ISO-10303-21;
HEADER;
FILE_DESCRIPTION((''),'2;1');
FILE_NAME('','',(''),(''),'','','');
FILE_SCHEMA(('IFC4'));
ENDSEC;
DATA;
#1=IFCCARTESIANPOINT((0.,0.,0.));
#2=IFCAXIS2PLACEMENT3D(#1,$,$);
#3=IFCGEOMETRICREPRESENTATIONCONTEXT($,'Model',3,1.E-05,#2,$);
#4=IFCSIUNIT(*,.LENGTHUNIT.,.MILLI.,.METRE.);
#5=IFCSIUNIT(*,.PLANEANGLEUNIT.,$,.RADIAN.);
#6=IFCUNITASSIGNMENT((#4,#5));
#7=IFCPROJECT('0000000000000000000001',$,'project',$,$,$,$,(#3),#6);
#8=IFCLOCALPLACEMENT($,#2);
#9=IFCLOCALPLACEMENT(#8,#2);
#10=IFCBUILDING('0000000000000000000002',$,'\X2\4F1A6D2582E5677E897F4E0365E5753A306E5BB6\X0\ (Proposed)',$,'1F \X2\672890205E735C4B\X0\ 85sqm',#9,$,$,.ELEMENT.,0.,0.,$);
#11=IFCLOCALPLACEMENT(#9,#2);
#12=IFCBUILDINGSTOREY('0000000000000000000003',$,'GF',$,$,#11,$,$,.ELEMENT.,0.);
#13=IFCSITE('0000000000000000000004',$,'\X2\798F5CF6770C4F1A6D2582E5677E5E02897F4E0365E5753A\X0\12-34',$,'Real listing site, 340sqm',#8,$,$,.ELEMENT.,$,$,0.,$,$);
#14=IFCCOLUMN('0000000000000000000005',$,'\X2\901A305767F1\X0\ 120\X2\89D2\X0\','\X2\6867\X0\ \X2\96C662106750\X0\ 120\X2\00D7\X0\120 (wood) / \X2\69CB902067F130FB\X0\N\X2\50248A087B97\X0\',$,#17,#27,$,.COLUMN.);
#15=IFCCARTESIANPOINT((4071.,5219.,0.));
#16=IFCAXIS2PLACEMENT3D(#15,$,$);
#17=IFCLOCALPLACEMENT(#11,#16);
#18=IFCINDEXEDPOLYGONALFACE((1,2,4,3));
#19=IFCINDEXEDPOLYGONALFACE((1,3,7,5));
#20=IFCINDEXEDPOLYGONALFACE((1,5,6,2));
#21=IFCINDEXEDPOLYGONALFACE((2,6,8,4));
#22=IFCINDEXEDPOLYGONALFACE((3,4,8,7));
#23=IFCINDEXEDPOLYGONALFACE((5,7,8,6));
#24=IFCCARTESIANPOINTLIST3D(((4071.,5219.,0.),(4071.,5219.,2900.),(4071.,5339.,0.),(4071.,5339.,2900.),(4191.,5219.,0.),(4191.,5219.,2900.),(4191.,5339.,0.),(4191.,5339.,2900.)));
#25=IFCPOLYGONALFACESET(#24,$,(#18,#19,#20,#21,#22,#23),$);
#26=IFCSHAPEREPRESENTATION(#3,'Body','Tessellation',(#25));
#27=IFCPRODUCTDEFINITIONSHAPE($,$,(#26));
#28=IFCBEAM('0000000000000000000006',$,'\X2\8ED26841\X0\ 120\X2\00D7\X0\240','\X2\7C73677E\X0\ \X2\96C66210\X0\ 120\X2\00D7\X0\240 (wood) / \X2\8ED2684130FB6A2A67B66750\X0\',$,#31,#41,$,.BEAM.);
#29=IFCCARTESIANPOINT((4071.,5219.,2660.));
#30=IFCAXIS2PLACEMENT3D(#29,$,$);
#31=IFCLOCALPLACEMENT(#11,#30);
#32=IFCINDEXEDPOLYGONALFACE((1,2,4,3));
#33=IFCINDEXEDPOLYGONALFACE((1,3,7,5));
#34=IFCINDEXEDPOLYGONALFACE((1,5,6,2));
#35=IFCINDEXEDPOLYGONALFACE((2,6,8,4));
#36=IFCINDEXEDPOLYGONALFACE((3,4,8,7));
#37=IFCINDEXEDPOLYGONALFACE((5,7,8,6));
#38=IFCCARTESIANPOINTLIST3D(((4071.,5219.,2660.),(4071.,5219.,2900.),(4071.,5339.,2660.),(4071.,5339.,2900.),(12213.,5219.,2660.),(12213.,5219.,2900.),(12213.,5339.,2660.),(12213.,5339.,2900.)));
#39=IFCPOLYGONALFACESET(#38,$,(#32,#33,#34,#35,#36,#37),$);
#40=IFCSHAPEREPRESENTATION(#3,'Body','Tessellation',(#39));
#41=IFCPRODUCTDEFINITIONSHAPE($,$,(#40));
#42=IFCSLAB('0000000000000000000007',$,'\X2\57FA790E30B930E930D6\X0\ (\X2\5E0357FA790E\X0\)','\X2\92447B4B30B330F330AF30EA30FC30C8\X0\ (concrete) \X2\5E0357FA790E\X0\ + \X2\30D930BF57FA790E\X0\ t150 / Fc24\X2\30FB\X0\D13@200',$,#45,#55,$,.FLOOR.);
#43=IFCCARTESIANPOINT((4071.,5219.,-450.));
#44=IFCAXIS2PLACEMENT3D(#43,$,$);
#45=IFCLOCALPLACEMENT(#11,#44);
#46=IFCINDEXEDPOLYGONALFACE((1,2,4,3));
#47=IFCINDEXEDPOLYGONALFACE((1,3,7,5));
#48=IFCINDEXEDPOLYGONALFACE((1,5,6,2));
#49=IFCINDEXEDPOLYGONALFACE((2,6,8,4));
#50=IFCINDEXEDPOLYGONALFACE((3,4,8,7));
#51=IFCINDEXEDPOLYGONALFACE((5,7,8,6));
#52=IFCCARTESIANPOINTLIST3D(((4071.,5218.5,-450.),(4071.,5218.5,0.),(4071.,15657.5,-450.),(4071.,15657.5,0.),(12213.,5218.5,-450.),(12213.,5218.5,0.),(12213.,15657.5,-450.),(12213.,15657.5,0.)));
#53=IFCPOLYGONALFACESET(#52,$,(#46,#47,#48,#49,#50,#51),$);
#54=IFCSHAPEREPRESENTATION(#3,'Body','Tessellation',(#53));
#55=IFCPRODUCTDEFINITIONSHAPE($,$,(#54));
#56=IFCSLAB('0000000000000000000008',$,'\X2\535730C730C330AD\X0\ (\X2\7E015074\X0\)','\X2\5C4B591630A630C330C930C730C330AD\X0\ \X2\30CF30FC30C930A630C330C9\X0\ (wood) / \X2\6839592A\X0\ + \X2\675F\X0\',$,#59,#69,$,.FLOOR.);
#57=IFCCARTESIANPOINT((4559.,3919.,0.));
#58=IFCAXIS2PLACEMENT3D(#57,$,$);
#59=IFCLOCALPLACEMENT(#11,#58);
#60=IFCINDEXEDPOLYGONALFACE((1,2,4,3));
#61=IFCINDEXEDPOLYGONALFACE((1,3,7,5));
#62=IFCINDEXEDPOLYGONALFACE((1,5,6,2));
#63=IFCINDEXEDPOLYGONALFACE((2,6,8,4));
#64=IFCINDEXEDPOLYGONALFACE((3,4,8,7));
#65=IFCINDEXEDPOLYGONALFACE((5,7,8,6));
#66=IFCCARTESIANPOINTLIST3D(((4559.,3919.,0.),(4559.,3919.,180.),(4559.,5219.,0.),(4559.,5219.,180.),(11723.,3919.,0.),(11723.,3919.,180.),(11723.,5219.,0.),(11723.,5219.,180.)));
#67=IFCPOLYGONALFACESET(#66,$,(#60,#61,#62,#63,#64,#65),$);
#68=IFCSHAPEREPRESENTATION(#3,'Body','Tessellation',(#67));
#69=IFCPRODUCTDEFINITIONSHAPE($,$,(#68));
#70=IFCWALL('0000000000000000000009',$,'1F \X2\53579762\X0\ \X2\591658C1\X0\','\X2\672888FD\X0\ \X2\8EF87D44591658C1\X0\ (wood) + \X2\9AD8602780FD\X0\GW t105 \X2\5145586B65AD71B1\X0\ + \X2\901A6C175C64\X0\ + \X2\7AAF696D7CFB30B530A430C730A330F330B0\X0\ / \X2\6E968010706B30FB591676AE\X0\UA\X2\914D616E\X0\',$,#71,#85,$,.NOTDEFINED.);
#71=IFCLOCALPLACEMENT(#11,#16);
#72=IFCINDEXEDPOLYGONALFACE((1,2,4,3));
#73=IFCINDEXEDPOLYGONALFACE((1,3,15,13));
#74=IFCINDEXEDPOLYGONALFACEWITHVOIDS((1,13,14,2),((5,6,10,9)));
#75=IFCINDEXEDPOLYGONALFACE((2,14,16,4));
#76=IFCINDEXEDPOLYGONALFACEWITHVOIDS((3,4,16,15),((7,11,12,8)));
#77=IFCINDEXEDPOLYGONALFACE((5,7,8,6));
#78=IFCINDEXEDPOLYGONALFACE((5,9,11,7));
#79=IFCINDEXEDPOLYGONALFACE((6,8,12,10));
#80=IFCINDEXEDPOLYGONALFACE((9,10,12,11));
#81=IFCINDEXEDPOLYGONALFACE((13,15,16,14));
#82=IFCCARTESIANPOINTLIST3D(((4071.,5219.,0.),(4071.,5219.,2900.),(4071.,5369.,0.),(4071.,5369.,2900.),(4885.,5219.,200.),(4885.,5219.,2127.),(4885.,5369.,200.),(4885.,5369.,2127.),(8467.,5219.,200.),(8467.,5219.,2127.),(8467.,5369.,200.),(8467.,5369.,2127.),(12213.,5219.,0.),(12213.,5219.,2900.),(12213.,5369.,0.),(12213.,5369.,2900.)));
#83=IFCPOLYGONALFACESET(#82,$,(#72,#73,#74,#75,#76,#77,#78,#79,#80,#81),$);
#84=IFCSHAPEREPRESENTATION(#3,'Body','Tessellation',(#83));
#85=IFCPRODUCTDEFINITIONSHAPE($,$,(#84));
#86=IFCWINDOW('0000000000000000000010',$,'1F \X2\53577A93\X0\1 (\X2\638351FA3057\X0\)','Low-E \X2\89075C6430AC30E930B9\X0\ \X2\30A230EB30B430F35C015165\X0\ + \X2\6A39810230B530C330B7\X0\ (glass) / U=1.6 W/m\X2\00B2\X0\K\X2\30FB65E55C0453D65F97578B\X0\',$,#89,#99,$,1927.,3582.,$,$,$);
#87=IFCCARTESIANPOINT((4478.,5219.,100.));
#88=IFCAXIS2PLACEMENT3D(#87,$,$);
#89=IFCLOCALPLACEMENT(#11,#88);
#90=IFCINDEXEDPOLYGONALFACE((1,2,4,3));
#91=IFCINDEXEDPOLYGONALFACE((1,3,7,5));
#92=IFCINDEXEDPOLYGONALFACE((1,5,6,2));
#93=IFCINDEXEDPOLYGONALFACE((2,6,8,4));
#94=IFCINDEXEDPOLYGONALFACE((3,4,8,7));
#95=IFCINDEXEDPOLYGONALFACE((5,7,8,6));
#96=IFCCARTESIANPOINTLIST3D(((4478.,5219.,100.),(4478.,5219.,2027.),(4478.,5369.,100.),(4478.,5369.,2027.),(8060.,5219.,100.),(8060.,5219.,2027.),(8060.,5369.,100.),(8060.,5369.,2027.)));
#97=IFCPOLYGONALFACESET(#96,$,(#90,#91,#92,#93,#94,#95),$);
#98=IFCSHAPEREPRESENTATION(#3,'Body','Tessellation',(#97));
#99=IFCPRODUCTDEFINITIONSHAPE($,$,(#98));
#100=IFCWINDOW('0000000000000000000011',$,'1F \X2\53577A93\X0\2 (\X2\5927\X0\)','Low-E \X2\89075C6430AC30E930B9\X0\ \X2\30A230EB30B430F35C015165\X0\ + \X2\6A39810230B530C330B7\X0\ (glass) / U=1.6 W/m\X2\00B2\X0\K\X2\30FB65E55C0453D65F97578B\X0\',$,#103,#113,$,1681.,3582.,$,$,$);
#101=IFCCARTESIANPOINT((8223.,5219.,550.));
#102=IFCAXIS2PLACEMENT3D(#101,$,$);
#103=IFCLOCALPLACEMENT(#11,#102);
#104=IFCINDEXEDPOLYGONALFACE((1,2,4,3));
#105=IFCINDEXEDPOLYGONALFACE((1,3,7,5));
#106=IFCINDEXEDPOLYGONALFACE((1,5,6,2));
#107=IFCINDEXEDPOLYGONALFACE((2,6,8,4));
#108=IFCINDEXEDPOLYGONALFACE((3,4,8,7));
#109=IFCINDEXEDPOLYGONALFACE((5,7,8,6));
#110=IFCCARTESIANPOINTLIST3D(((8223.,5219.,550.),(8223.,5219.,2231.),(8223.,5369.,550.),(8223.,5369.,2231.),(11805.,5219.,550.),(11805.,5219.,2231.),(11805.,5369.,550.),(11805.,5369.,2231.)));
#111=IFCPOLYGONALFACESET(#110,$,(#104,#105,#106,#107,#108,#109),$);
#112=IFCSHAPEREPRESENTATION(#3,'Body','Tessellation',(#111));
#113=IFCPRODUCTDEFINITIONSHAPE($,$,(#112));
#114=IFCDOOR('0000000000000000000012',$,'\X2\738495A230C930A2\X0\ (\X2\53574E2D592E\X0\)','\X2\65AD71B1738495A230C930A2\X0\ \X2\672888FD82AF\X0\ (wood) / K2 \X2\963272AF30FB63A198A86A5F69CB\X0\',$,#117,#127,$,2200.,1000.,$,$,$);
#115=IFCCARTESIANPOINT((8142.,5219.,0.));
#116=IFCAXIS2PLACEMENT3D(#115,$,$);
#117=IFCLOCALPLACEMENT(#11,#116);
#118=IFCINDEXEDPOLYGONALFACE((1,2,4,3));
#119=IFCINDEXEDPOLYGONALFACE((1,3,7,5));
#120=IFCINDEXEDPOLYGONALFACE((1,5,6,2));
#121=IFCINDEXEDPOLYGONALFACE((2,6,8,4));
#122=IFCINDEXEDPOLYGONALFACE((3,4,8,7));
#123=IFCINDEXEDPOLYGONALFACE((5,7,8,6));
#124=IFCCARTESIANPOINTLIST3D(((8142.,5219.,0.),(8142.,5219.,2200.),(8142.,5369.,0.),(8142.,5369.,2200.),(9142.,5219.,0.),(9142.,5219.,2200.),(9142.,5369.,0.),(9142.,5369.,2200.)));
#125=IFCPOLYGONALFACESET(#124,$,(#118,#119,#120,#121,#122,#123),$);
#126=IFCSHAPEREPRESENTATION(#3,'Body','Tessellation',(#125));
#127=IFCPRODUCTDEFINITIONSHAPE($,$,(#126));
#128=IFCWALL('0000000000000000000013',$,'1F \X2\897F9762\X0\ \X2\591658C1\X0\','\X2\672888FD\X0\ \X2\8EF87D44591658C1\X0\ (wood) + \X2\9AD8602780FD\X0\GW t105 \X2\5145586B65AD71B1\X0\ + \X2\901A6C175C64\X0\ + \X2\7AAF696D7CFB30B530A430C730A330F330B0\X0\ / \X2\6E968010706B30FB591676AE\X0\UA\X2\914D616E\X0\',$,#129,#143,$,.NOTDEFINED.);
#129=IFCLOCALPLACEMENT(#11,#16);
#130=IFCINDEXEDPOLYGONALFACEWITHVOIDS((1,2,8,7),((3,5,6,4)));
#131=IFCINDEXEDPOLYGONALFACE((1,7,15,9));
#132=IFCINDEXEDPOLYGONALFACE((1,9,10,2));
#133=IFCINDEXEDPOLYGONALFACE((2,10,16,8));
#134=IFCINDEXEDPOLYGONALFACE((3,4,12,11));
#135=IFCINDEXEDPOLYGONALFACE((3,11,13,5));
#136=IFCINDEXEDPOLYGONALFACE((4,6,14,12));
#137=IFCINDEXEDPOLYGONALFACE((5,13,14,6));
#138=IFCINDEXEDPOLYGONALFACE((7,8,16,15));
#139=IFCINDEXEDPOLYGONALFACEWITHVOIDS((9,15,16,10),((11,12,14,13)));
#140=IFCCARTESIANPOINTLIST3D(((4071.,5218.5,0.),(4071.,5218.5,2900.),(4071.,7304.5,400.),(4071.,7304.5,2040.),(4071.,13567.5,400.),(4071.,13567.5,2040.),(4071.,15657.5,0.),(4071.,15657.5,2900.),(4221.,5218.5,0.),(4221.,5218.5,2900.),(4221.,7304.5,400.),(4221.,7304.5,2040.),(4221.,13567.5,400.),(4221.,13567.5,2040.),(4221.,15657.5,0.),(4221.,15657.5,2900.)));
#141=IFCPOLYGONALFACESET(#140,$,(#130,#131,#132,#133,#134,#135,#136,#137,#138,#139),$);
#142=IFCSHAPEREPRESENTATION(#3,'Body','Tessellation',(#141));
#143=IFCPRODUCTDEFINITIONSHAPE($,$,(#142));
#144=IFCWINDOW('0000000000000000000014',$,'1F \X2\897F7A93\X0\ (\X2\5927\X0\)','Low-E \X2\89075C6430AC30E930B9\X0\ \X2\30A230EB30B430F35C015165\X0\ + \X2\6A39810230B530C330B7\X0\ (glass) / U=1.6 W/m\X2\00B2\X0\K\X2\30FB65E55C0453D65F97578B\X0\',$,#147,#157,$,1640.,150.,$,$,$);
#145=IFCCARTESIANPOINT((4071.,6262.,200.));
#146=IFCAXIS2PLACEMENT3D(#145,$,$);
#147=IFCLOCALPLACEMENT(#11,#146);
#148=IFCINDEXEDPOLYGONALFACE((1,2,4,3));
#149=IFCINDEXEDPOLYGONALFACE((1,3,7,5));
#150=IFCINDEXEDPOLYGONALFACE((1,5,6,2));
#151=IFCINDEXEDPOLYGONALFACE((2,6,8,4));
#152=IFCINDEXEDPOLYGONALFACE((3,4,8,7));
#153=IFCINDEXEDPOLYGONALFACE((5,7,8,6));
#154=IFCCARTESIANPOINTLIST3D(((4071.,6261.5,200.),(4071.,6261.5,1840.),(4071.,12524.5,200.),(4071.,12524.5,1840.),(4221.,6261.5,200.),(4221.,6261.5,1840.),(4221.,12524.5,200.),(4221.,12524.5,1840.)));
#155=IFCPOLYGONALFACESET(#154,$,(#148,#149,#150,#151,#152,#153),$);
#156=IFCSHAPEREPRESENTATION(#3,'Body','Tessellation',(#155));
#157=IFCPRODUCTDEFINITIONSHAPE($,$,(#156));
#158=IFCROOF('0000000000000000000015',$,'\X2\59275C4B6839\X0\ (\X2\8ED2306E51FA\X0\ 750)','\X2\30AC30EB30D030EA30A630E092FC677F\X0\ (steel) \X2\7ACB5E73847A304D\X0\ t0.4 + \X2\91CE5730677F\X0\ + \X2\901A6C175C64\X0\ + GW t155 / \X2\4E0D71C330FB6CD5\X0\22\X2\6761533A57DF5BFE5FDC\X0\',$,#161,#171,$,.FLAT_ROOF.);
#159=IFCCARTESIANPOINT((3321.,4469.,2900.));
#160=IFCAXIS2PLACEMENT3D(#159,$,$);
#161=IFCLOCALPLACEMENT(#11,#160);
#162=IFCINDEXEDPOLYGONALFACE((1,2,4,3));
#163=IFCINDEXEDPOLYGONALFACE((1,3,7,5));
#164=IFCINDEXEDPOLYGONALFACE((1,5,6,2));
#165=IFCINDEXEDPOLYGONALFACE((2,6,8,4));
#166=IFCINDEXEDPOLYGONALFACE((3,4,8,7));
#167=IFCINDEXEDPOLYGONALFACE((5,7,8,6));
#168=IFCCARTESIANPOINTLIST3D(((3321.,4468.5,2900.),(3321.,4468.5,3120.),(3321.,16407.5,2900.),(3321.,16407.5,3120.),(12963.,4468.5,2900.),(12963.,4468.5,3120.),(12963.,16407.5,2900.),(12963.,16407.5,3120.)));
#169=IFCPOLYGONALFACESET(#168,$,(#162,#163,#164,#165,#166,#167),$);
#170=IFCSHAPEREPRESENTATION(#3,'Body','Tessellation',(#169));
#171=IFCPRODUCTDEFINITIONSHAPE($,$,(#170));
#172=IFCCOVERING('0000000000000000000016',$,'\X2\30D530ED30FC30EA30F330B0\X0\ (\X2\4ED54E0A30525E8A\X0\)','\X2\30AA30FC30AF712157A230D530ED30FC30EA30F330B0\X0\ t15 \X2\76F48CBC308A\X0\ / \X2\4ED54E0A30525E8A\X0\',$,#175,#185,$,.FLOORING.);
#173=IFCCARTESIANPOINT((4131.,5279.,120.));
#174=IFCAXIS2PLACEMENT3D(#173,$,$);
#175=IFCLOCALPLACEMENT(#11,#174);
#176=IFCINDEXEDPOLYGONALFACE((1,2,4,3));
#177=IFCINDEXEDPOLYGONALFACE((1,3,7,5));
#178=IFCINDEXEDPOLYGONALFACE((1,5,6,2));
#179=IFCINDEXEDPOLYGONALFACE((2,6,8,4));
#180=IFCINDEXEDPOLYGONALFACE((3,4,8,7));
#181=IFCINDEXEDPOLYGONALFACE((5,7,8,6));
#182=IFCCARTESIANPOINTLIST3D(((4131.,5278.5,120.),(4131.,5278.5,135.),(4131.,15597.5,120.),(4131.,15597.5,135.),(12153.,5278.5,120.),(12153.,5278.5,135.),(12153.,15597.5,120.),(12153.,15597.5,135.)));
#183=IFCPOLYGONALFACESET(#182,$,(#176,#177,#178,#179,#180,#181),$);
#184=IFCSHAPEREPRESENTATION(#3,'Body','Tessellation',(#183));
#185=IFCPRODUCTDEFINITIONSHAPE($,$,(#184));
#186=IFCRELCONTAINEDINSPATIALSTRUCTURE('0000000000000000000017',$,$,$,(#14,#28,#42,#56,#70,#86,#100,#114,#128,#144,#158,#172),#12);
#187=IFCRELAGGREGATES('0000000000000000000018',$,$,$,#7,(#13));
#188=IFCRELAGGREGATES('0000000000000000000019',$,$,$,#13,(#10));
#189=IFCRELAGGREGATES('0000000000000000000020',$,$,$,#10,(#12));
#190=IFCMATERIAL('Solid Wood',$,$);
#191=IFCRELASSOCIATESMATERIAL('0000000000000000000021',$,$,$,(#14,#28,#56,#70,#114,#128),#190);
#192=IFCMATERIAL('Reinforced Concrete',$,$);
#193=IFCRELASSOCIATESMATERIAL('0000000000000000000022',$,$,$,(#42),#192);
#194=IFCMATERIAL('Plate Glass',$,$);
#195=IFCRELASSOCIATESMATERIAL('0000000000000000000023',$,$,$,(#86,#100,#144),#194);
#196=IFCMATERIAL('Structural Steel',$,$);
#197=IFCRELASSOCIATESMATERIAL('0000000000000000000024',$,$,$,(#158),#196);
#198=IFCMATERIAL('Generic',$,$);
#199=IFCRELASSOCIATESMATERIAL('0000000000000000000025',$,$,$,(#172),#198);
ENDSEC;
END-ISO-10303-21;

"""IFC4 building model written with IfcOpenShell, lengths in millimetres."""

from ifc_helpers import new_model, si_unit, frame, frame_2d, origin, place, context, project, spatial, rectangle, extrude, material, element, fill, save


model = new_model("IFC4")

# Units and contexts
model_context = context("Model", 3, precision=1e-05, world=origin())
ifc_project = project(units=[si_unit("LENGTHUNIT", "METRE", prefix="MILLI"), si_unit("PLANEANGLEUNIT", "RADIAN")], contexts=[model_context])

# Site, building, storey
site_placement = place(None, origin())
site = spatial("IfcSite", under=ifc_project, at=site_placement, Name="福島県会津若松市西七日町12-34", ObjectType="Real listing site, 340sqm", CompositionType="ELEMENT", RefElevation=0.0)
building_placement = place(site_placement, origin())
building = spatial("IfcBuilding", under=site, at=building_placement, Name="会津若松西七日町の家 (Proposed)", ObjectType="1F 木造平屋 85sqm", CompositionType="ELEMENT", ElevationOfRefHeight=0.0, ElevationOfTerrain=0.0)
storey_placement = place(building_placement, origin())
storey = spatial("IfcBuildingStorey", under=building, at=storey_placement, Name="GF", CompositionType="ELEMENT", Elevation=0.0)

# Column
ifc_material_1 = material(Name="Solid Wood")
column_1_placement = place(storey_placement, frame((4071.0, 5219.0, 0.0)))
element("IfcColumn", 1, at=column_1_placement, inside=storey, material=ifc_material_1, Name="通し柱 120角", Description="桧 集成材 120×120 (wood) / 構造柱・N値計算", PredefinedType="COLUMN", context=model_context, shape_type="SweptSolid", body=[
    extrude(rectangle(XDim=120.0, YDim=120.0, at=frame_2d((60.0, 60.0))), frame((4071.0, 5219.0, 0.0)), (0.0, 0.0, 1.0), 2900.0),
])

# Beam
beam_1_placement = place(storey_placement, frame((4071.0, 5219.0, 2660.0)))
element("IfcBeam", 2, at=beam_1_placement, inside=storey, material=ifc_material_1, Name="軒桁 120×240", Description="米松 集成 120×240 (wood) / 軒桁・横架材", PredefinedType="BEAM", context=model_context, shape_type="SweptSolid", body=[
    extrude(rectangle(XDim=8142.0, YDim=120.0, at=frame_2d((4071.0, 60.0))), frame((4071.0, 5219.0, 2660.0)), (0.0, 0.0, 1.0), 240.0),
])

# Slabs
ifc_material_2 = material(Name="Reinforced Concrete")
slab_1_placement = place(storey_placement, frame((4071.0, 5219.0, -450.0)))
element("IfcSlab", 3, at=slab_1_placement, inside=storey, material=ifc_material_2, Name="基礎スラブ (布基礎)", Description="鉄筋コンクリート (concrete) 布基礎 + ベタ基礎 t150 / Fc24・D13@200", PredefinedType="FLOOR", context=model_context, shape_type="SweptSolid", body=[
    extrude(rectangle(XDim=8142.0, YDim=10439.0, at=frame_2d((4071.0, 5219.0))), frame((4071.0, 5219.0, -450.0)), (0.0, 0.0, 1.0), 450.0),
])
slab_2_placement = place(storey_placement, frame((4559.0, 3919.0, 0.0)))
element("IfcSlab", 4, at=slab_2_placement, inside=storey, material=ifc_material_1, Name="南デッキ (縁側)", Description="屋外ウッドデッキ ハードウッド (wood) / 根太 + 束", PredefinedType="FLOOR", context=model_context, shape_type="SweptSolid", body=[
    extrude(rectangle(XDim=7164.0, YDim=1300.0, at=frame_2d((3582.0, 650.0))), frame((4559.0, 3919.0, 0.0)), (0.0, 0.0, 1.0), 180.0),
])

# Wall, openings, windows, door
wall_1_placement = place(storey_placement, frame((4071.0, 5219.0, 0.0)))
wall_1 = element("IfcWall", 5, at=wall_1_placement, inside=storey, material=ifc_material_1, Name="1F 南面 外壁", Description="木製 軸組外壁 (wood) + 高性能GW t105 充填断熱 + 通気層 + 窯業系サイディング / 準耐火・外皮UA配慮", PredefinedType="NOTDEFINED", context=model_context, shape_type="SweptSolid", body=[
    extrude(rectangle(XDim=8142.0, YDim=150.0, at=frame_2d((4071.0, 75.0))), frame((4071.0, 5219.0, 0.0)), (0.0, 0.0, 1.0), 2900.0),
])
opening_1_placement = place(storey_placement, frame((4478.0, 5219.0, 100.0)))
opening_1 = element("IfcOpeningElement", 6, at=opening_1_placement, cuts=wall_1, PredefinedType="NOTDEFINED", context=model_context, shape_type="SweptSolid", body=[
    extrude(rectangle(XDim=3582.0, YDim=150.0, at=frame_2d((1791.0, 75.0))), frame((4478.0, 5219.0, 100.0)), (0.0, 0.0, 1.0), 1927.0),
])
opening_2_placement = place(storey_placement, frame((8223.0, 5219.0, 550.0)))
opening_2 = element("IfcOpeningElement", 7, at=opening_2_placement, cuts=wall_1, PredefinedType="NOTDEFINED", context=model_context, shape_type="SweptSolid", body=[
    extrude(rectangle(XDim=3582.0, YDim=150.0, at=frame_2d((1791.0, 75.0))), frame((8223.0, 5219.0, 550.0)), (0.0, 0.0, 1.0), 1681.0),
])
opening_3_placement = place(storey_placement, frame((8142.0, 5219.0, 0.0)))
opening_3 = element("IfcOpeningElement", 8, at=opening_3_placement, cuts=wall_1, PredefinedType="NOTDEFINED", context=model_context, shape_type="SweptSolid", body=[
    extrude(rectangle(XDim=1000.0, YDim=150.0, at=frame_2d((500.0, 75.0))), frame((8142.0, 5219.0, 0.0)), (0.0, 0.0, 1.0), 2200.0),
])
ifc_material_3 = material(Name="Plate Glass")
window_1_placement = place(storey_placement, frame((4478.0, 5219.0, 100.0)))
window_1 = element("IfcWindow", 9, at=window_1_placement, inside=storey, material=ifc_material_3, Name="1F 南窓1 (掃出し)", Description="Low-E 複層ガラス アルゴン封入 + 樹脂サッシ (glass) / U=1.6 W/m²K・日射取得型", OverallHeight=1927.0, OverallWidth=3582.0, context=model_context, shape_type="SweptSolid", body=[
    extrude(rectangle(XDim=3582.0, YDim=150.0, at=frame_2d((1791.0, 75.0))), frame((4478.0, 5219.0, 100.0)), (0.0, 0.0, 1.0), 1927.0),
])
fill(opening_1, window_1)
window_2_placement = place(storey_placement, frame((8223.0, 5219.0, 550.0)))
window_2 = element("IfcWindow", 10, at=window_2_placement, inside=storey, material=ifc_material_3, Name="1F 南窓2 (大)", Description="Low-E 複層ガラス アルゴン封入 + 樹脂サッシ (glass) / U=1.6 W/m²K・日射取得型", OverallHeight=1681.0, OverallWidth=3582.0, context=model_context, shape_type="SweptSolid", body=[
    extrude(rectangle(XDim=3582.0, YDim=150.0, at=frame_2d((1791.0, 75.0))), frame((8223.0, 5219.0, 550.0)), (0.0, 0.0, 1.0), 1681.0),
])
fill(opening_2, window_2)
door_placement = place(storey_placement, frame((8142.0, 5219.0, 0.0)))
door = element("IfcDoor", 11, at=door_placement, inside=storey, material=ifc_material_1, Name="玄関ドア (南中央)", Description="断熱玄関ドア 木製芯 (wood) / K2 防犯・採風機構", OverallHeight=2200.0, OverallWidth=1000.0, context=model_context, shape_type="SweptSolid", body=[
    extrude(rectangle(XDim=1000.0, YDim=150.0, at=frame_2d((500.0, 75.0))), frame((8142.0, 5219.0, 0.0)), (0.0, 0.0, 1.0), 2200.0),
])
fill(opening_3, door)

# Wall, opening, window
wall_2_placement = place(storey_placement, frame((4071.0, 5219.0, 0.0)))
wall_2 = element("IfcWall", 12, at=wall_2_placement, inside=storey, material=ifc_material_1, Name="1F 西面 外壁", Description="木製 軸組外壁 (wood) + 高性能GW t105 充填断熱 + 通気層 + 窯業系サイディング / 準耐火・外皮UA配慮", PredefinedType="NOTDEFINED", context=model_context, shape_type="SweptSolid", body=[
    extrude(rectangle(XDim=150.0, YDim=10439.0, at=frame_2d((75.0, 5219.0))), frame((4071.0, 5219.0, 0.0)), (0.0, 0.0, 1.0), 2900.0),
])
opening_4_placement = place(storey_placement, frame((4071.0, 6262.0, 200.0)))
opening_4 = element("IfcOpeningElement", 13, at=opening_4_placement, cuts=wall_2, PredefinedType="NOTDEFINED", context=model_context, shape_type="SweptSolid", body=[
    extrude(rectangle(XDim=150.0, YDim=6263.0, at=frame_2d((75.0, 3131.0))), frame((4071.0, 6262.0, 200.0)), (0.0, 0.0, 1.0), 1640.0),
])
window_3_placement = place(storey_placement, frame((4071.0, 6262.0, 200.0)))
window_3 = element("IfcWindow", 14, at=window_3_placement, inside=storey, material=ifc_material_3, Name="1F 西窓 (大)", Description="Low-E 複層ガラス アルゴン封入 + 樹脂サッシ (glass) / U=1.6 W/m²K・日射取得型", OverallHeight=1640.0, OverallWidth=150.0, context=model_context, shape_type="SweptSolid", body=[
    extrude(rectangle(XDim=150.0, YDim=6263.0, at=frame_2d((75.0, 3131.0))), frame((4071.0, 6262.0, 200.0)), (0.0, 0.0, 1.0), 1640.0),
])
fill(opening_4, window_3)

# Roof
ifc_material_4 = material(Name="Structural Steel")
roof_placement = place(storey_placement, frame((3321.0, 4469.0, 2900.0)))
element("IfcRoof", 15, at=roof_placement, inside=storey, material=ifc_material_4, Name="大屋根 (軒の出 750)", Description="ガルバリウム鋼板 (steel) 立平葺き t0.4 + 野地板 + 通気層 + GW t155 / 不燃・法22条区域対応", PredefinedType="FLAT_ROOF", context=model_context, shape_type="SweptSolid", body=[
    extrude(rectangle(XDim=9642.0, YDim=11939.0, at=frame_2d((4821.0, 5969.0))), frame((3321.0, 4469.0, 2900.0)), (0.0, 0.0, 1.0), 220.0),
])

# Covering
ifc_material_5 = material(Name="Generic")
covering_1_placement = place(storey_placement, frame((4131.0, 5279.0, 120.0)))
element("IfcCovering", 16, at=covering_1_placement, inside=storey, material=ifc_material_5, Name="フローリング (仕上げ床)", Description="オーク無垢フローリング t15 直貼り / 仕上げ床", PredefinedType="FLOORING", context=model_context, shape_type="SweptSolid", body=[
    extrude(rectangle(XDim=8022.0, YDim=10319.0, at=frame_2d((4011.0, 5159.0))), frame((4131.0, 5279.0, 120.0)), (0.0, 0.0, 1.0), 15.0),
])

save(model, "model.ifc")
